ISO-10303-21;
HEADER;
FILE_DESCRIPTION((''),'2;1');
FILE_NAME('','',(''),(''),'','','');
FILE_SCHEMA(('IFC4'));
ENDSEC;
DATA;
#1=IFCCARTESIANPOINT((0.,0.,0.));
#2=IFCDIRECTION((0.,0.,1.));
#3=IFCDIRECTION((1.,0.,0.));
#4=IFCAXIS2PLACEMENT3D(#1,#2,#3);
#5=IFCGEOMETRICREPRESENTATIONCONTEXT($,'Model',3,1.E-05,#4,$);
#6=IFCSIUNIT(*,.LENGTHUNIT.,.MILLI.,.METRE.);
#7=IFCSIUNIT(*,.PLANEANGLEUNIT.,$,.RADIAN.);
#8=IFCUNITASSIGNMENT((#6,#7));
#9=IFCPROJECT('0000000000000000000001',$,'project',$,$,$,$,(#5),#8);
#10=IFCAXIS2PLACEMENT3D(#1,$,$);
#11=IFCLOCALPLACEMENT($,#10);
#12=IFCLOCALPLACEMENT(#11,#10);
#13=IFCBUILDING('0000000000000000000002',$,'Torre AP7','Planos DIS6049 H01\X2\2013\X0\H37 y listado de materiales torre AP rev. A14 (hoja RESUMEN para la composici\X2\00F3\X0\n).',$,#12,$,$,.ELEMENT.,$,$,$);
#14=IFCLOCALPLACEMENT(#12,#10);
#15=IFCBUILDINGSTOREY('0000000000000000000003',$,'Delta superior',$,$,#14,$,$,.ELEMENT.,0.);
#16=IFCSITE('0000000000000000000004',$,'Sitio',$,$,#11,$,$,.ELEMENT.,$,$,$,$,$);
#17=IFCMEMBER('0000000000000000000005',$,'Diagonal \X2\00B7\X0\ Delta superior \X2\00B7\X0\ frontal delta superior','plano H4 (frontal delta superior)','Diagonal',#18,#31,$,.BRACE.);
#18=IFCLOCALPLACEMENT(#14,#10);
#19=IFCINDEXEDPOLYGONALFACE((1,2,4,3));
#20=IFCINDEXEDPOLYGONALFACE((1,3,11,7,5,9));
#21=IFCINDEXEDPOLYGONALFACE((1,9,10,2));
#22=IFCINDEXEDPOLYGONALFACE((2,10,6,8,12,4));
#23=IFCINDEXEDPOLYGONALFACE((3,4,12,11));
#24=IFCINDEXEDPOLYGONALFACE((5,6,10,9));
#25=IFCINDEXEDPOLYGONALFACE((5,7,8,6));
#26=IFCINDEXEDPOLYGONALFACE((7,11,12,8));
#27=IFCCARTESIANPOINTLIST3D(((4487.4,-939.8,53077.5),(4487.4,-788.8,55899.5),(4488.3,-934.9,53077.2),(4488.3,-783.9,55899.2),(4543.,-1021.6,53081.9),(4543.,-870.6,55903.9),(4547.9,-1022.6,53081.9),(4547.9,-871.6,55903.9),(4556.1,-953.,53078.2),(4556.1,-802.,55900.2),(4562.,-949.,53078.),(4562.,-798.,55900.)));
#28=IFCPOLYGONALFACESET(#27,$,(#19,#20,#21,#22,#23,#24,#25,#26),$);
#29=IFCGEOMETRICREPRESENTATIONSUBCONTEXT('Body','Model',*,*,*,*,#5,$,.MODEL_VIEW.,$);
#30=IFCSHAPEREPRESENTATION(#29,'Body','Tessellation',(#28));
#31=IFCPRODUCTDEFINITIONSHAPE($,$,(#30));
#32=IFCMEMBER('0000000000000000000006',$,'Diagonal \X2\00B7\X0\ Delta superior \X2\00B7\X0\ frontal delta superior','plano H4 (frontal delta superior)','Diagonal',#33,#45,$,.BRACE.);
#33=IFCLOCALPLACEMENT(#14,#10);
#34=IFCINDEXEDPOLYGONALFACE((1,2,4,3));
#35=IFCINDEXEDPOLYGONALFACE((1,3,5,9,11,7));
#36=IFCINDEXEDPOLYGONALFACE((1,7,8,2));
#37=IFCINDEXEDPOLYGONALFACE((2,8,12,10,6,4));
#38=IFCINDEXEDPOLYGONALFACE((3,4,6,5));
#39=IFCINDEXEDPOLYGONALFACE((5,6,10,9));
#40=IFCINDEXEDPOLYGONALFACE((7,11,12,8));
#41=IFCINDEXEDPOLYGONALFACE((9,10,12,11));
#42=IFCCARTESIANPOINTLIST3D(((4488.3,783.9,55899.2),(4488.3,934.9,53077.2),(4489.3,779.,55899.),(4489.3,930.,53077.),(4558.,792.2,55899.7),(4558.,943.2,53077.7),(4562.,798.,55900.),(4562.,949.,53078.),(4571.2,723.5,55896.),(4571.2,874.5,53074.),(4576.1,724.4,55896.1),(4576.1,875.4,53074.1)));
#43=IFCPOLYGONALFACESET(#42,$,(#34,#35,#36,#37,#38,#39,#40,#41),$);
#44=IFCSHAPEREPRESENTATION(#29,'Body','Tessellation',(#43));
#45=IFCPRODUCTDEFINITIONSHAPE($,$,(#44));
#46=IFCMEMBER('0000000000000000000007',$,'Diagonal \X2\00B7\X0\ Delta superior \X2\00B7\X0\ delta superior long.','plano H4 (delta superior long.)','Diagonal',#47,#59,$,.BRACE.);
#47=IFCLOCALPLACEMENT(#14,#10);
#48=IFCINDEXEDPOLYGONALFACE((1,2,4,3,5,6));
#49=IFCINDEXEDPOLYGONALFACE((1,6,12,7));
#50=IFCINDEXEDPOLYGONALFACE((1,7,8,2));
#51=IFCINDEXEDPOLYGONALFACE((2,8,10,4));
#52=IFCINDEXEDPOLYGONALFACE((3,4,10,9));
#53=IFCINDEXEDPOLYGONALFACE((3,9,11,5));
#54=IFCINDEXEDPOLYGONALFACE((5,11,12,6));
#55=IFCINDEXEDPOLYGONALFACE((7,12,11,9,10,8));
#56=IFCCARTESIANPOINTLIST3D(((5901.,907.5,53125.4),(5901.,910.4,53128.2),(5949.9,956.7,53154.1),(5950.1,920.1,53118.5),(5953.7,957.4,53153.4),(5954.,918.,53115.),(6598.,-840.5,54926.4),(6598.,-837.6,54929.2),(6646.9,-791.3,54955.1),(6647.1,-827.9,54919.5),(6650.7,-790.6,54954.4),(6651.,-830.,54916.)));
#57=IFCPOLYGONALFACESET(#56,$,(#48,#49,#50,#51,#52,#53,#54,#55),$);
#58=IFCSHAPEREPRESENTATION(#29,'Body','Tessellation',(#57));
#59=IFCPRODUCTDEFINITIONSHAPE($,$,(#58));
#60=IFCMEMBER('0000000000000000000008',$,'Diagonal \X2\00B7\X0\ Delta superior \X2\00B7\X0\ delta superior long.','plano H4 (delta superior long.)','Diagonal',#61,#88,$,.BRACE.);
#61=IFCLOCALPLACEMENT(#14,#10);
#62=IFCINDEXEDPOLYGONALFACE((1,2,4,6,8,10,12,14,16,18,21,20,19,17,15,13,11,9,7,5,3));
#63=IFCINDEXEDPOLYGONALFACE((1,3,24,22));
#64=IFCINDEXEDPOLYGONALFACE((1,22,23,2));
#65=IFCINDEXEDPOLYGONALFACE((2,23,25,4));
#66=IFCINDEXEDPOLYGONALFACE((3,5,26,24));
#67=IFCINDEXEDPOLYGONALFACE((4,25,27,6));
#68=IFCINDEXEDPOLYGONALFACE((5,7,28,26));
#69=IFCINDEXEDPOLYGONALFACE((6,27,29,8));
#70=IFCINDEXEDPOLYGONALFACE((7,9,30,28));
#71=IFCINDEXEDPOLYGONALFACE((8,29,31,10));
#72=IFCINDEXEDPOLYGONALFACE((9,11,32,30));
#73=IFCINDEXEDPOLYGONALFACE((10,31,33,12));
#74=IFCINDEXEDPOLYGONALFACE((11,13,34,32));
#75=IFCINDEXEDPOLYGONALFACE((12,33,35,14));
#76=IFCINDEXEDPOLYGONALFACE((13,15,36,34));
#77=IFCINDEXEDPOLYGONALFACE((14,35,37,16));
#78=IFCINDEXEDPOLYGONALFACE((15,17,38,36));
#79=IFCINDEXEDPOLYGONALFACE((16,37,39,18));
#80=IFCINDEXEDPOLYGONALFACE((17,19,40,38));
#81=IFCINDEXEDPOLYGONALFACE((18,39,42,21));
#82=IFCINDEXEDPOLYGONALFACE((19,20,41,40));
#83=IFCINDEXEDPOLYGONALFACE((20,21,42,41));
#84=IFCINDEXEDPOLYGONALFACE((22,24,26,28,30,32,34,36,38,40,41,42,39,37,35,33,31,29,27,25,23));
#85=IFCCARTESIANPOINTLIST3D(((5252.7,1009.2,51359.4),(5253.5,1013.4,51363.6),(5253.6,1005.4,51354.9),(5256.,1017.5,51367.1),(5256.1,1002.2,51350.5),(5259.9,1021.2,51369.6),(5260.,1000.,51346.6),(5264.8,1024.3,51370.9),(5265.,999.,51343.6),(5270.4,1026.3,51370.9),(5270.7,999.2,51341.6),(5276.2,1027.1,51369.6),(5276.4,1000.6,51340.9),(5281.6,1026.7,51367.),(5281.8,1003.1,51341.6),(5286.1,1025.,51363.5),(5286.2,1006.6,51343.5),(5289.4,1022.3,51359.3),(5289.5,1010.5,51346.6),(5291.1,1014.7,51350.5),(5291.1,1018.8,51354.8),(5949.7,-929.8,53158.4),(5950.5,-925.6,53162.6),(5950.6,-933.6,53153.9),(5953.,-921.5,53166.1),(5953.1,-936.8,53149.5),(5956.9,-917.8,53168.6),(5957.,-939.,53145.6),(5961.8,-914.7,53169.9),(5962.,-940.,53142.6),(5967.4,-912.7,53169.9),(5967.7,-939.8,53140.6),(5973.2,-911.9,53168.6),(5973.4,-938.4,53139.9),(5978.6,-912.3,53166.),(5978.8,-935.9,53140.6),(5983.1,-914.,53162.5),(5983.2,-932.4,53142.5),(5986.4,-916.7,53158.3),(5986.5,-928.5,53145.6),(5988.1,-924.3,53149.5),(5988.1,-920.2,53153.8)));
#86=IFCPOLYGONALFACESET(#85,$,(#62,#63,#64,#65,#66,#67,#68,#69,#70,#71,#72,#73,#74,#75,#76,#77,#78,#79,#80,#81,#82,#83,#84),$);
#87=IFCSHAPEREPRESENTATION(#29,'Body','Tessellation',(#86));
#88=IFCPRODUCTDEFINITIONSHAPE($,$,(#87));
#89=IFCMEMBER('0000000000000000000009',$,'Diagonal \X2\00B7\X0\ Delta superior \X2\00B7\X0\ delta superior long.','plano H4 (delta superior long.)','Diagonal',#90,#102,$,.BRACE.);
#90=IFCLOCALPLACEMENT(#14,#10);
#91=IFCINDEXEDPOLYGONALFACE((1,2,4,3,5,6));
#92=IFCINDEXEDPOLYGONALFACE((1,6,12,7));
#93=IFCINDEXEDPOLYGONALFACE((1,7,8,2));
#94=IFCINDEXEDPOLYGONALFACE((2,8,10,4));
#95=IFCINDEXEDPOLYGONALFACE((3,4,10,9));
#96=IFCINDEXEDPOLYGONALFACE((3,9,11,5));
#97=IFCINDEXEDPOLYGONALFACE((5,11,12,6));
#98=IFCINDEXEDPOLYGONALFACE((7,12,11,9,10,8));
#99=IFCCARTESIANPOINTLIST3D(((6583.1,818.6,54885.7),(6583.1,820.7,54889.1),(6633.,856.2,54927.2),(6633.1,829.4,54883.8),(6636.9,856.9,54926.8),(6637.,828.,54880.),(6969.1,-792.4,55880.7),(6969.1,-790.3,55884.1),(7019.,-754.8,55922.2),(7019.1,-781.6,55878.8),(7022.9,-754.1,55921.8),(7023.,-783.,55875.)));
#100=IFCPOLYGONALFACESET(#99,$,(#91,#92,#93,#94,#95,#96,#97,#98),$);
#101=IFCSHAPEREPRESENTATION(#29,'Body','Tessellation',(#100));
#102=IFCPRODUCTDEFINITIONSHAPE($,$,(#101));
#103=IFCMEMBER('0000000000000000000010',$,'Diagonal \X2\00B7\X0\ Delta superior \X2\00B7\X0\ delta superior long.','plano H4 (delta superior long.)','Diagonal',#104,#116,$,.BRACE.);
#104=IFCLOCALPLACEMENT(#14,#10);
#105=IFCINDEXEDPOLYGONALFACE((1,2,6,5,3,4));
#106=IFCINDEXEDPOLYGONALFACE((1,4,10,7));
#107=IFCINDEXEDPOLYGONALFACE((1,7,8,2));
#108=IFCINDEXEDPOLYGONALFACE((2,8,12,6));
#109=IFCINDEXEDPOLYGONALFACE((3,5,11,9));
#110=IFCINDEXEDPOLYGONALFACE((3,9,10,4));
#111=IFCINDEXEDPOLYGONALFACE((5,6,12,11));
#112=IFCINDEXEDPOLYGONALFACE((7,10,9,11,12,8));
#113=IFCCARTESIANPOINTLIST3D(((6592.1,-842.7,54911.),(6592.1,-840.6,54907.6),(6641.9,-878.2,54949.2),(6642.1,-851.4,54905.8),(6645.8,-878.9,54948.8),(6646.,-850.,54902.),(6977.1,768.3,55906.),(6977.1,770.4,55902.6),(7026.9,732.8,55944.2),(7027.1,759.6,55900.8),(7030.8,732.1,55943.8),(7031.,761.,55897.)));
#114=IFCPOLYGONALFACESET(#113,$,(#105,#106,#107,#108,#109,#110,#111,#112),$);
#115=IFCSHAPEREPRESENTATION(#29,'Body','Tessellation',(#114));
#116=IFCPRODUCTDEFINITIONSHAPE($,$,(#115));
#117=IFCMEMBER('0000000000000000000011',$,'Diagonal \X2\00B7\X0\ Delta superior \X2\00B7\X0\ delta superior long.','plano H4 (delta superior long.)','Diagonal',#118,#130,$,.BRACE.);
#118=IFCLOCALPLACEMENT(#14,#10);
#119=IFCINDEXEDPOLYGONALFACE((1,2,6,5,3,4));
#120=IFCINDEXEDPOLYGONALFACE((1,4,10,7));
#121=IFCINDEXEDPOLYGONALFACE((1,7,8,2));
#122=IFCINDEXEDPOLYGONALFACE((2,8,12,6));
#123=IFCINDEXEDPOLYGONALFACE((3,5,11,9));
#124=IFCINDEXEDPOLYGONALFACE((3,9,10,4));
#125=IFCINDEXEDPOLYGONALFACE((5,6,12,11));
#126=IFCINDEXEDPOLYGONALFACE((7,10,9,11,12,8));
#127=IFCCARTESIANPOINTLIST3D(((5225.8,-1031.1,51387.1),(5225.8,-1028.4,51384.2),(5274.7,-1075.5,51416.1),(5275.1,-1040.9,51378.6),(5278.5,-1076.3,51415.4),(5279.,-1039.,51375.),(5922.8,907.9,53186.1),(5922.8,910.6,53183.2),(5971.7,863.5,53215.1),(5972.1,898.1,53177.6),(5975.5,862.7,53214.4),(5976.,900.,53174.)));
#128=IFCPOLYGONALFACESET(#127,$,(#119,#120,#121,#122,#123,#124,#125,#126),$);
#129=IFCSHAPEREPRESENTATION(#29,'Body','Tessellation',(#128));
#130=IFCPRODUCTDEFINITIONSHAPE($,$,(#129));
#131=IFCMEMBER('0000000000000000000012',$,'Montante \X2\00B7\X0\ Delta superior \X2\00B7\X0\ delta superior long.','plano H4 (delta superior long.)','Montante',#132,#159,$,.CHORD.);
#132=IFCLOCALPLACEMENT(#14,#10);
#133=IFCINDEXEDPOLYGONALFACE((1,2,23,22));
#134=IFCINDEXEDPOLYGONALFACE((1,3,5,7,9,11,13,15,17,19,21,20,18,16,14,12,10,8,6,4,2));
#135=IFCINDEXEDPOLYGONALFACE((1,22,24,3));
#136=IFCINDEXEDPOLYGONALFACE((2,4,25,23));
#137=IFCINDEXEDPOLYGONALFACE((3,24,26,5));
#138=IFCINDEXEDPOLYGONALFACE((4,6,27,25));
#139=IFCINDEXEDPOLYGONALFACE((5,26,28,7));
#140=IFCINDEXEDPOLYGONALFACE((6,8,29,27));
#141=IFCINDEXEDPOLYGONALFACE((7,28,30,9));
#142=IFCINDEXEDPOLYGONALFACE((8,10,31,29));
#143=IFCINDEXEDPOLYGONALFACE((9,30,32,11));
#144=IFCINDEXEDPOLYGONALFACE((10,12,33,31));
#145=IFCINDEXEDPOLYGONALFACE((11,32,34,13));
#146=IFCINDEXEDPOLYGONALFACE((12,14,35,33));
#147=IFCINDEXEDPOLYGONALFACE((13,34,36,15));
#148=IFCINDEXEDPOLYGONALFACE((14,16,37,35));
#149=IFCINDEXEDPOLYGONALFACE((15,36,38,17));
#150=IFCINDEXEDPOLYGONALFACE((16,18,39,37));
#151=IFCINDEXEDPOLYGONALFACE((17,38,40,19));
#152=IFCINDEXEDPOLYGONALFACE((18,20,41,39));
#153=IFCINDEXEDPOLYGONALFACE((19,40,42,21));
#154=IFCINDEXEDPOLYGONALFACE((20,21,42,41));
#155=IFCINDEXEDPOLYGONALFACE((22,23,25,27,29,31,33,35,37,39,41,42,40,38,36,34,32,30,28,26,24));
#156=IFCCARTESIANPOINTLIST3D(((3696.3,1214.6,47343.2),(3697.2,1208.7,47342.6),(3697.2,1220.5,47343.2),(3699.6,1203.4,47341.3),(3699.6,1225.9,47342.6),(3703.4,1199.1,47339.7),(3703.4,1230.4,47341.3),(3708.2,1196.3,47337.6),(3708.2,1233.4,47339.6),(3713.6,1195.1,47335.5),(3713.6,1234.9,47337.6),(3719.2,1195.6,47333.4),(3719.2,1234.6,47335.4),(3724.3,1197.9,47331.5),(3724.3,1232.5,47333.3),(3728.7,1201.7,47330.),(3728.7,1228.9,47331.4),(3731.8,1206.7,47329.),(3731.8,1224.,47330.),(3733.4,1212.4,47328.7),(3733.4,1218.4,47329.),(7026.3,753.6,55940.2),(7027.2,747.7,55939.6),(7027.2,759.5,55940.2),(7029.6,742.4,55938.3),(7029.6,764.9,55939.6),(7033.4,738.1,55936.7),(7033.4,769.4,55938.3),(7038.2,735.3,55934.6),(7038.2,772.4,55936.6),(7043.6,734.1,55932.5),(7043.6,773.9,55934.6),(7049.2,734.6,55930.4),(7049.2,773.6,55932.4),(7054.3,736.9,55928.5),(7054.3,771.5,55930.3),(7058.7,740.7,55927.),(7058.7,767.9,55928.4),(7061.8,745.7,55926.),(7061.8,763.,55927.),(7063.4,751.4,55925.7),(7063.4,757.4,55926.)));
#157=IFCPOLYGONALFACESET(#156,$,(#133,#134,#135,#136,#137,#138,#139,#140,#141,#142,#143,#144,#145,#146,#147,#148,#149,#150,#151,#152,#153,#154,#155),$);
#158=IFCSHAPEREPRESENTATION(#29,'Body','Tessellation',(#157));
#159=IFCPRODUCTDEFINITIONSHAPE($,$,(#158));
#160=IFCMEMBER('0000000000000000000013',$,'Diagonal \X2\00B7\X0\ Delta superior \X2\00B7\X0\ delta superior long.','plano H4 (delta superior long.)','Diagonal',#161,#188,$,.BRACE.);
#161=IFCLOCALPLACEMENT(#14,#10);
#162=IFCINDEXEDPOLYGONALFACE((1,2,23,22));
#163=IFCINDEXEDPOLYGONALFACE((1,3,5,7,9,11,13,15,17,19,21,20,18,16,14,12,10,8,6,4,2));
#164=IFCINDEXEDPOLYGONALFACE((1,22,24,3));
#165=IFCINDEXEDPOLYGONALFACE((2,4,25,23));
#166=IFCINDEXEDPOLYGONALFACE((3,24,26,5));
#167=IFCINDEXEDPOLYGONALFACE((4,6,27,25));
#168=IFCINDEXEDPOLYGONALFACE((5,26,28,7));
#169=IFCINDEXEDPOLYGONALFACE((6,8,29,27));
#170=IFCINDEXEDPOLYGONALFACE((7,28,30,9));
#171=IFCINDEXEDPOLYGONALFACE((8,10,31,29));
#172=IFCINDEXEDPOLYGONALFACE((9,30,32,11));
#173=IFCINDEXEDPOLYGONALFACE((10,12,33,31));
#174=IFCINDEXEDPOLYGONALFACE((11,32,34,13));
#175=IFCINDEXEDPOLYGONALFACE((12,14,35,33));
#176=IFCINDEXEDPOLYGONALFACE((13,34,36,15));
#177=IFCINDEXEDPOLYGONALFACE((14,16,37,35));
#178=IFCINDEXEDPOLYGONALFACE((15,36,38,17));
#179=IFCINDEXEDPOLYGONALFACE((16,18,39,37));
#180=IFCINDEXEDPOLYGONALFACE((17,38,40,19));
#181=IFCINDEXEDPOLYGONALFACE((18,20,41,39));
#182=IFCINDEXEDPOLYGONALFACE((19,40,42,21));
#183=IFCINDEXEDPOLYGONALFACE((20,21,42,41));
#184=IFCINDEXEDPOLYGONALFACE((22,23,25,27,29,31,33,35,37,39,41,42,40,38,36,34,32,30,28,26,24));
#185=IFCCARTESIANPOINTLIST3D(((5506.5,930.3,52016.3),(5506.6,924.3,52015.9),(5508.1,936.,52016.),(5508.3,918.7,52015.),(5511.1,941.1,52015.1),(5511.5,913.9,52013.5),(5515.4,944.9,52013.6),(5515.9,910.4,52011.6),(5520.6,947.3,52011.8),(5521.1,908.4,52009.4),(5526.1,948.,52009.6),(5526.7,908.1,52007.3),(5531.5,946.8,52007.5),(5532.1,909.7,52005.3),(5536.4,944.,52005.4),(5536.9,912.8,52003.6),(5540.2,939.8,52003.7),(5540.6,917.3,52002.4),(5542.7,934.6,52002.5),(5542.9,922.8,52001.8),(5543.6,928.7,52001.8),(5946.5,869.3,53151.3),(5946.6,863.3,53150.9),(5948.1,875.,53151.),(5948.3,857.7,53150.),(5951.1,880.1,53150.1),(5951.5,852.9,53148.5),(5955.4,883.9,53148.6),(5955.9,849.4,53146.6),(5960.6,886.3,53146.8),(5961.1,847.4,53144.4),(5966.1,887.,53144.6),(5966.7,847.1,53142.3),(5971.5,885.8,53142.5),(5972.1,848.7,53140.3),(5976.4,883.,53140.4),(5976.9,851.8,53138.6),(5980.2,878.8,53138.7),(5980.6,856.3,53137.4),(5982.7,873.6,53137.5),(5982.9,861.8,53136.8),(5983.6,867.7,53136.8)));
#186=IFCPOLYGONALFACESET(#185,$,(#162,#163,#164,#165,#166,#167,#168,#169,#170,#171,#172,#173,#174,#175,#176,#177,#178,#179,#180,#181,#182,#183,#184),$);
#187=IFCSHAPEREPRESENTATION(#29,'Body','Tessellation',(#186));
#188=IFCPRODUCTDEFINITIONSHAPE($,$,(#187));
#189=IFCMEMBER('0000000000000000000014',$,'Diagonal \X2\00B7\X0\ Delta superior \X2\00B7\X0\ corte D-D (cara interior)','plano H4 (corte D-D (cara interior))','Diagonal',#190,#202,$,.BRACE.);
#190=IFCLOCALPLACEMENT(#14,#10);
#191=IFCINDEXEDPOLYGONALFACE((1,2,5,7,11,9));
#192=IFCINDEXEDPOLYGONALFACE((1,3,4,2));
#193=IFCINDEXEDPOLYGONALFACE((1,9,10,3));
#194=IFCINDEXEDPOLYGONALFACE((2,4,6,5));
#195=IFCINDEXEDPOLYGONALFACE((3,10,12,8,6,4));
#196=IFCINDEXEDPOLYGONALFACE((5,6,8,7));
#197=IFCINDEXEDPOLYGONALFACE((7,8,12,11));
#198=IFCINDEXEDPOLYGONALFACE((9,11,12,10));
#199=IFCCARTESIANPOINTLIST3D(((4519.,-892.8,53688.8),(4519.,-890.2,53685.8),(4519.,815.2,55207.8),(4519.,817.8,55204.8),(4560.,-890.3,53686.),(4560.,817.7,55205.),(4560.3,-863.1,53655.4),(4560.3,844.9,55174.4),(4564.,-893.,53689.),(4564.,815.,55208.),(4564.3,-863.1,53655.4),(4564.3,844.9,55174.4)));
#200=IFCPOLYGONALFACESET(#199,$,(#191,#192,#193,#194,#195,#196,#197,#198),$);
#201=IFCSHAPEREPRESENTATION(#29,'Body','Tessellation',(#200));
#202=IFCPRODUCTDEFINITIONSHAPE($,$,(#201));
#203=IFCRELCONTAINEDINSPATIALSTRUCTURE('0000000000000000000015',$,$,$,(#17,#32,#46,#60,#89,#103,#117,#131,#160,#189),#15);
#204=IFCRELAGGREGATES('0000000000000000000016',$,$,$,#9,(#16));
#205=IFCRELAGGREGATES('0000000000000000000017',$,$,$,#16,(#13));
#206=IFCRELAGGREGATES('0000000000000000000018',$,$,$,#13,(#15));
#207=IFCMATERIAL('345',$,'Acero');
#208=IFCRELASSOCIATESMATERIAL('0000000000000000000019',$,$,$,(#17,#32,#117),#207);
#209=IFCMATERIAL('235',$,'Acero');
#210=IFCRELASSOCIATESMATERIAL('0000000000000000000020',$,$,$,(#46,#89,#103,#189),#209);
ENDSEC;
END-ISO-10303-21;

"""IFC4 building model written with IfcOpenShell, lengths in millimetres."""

from ifc_helpers import new_model, si_unit, frame, frame_2d, origin, origin_with_axes, place, context, subcontext, project, spatial, circle, l_section, extrude, material, element, save


model = new_model("IFC4")

# Units and contexts
model_context = context("Model", 3, precision=1e-05, world=origin_with_axes())
body_context = subcontext(model_context, "Body", "Model", "MODEL_VIEW")
ifc_project = project(units=[si_unit("LENGTHUNIT", "METRE", prefix="MILLI"), si_unit("PLANEANGLEUNIT", "RADIAN")], contexts=[model_context])

# Site, building, storey
site_placement = place(None, origin())
site = spatial("IfcSite", under=ifc_project, at=site_placement, Name="Sitio", CompositionType="ELEMENT")
building_placement = place(site_placement, origin())
building = spatial("IfcBuilding", under=site, at=building_placement, Name="Torre AP7", Description="Planos DIS6049 H01–H37 y listado de materiales torre AP rev. A14 (hoja RESUMEN para la composición).", CompositionType="ELEMENT")
storey_placement = place(building_placement, origin())
storey = spatial("IfcBuildingStorey", under=building, at=storey_placement, Name="Delta superior", CompositionType="ELEMENT", Elevation=0.0)

# Members
ifc_material_1 = material(Name="235", Category="Acero")
ifc_material_2 = material(Name="345", Category="Acero")
for number, where, z_axis, x_axis, name in (
    (1, (4562.0, -949.0, 53078.0), (0.0, 0.053432, 0.998572), (-0.982208, 0.187529, -0.010034), "Diagonal · Delta superior · frontal delta superior"),
    (2, (4562.0, 949.0, 53078.0), (0.0, -0.053432, 0.998572), (-0.982208, -0.187529, -0.010034), "Diagonal · Delta superior · frontal delta superior"),
):
    element("IfcMember", number, at=place(storey_placement, frame(where, z_axis=z_axis, x_axis=x_axis)), inside=storey, material=ifc_material_2, Name=name, Description="plano H4 (frontal delta superior)", ObjectType="Diagonal", PredefinedType="BRACE", context=body_context, shape_type="SweptSolid", body=[
        extrude(l_section(Depth=75.0, Width=75.0, Thickness=5.0, at=frame_2d((37.5, 37.5))), None, (0.0, 0.0, 1.0), 2826.0),
    ])
member_1_placement = place(storey_placement, frame((6651.0, -830.0, 54916.0), z_axis=(-0.267584, 0.671072, -0.691419), x_axis=(-0.963521, -0.190088, 0.188396)))
element("IfcMember", 3, at=member_1_placement, inside=storey, material=ifc_material_1, Name="Diagonal · Delta superior · delta superior long.", Description="plano H4 (delta superior long.)", ObjectType="Diagonal", PredefinedType="BRACE", context=body_context, shape_type="SweptSolid", body=[
    extrude(l_section(Depth=55.0, Width=55.0, Thickness=4.0, at=frame_2d((27.5, 27.5))), None, (0.0, 0.0, 1.0), 2604.8),
])
member_2_placement = place(storey_placement, frame((5969.0, -926.0, 53155.0), z_axis=(-0.254816, 0.708877, -0.657695), x_axis=(-0.966975, -0.190493, 0.169325)))
element("IfcMember", 4, at=member_2_placement, inside=storey, Name="Diagonal · Delta superior · delta superior long.", Description="plano H4 (delta superior long.)", ObjectType="Diagonal", PredefinedType="BRACE", context=body_context, shape_type="SweptSolid", body=[
    extrude(circle(Radius=20.0), None, (0.0, 0.0, 1.0), 2735.3),
])
member_3_placement = place(storey_placement, frame((7023.0, -783.0, 55875.0), z_axis=(-0.199747, 0.833659, -0.514892), x_axis=(-0.979846, -0.170873, 0.103461)))
element("IfcMember", 5, at=member_3_placement, inside=storey, material=ifc_material_1, Name="Diagonal · Delta superior · delta superior long.", Description="plano H4 (delta superior long.)", ObjectType="Diagonal", PredefinedType="BRACE", context=body_context, shape_type="SweptSolid", body=[
    extrude(l_section(Depth=55.0, Width=55.0, Thickness=4.0, at=frame_2d((27.5, 27.5))), None, (0.0, 0.0, 1.0), 1932.4),
])
member_4_placement = place(storey_placement, frame((6646.0, -850.0, 54902.0), z_axis=(0.19925, 0.833745, 0.514945), x_axis=(-0.979943, 0.171353, 0.101736)))
element("IfcMember", 6, at=member_4_placement, inside=storey, material=ifc_material_1, Name="Diagonal · Delta superior · delta superior long.", Description="plano H4 (delta superior long.)", ObjectType="Diagonal", PredefinedType="BRACE", context=body_context, shape_type="SweptSolid", body=[
    extrude(l_section(Depth=55.0, Width=55.0, Thickness=4.0, at=frame_2d((27.5, 27.5))), None, (0.0, 0.0, 1.0), 1932.2),
])
member_5_placement = place(storey_placement, frame((5279.0, -1039.0, 51375.0), z_axis=(0.254816, 0.708877, 0.657695), x_axis=(-0.966953, 0.192686, 0.166953)))
element("IfcMember", 7, at=member_5_placement, inside=storey, material=ifc_material_2, Name="Diagonal · Delta superior · delta superior long.", Description="plano H4 (delta superior long.)", ObjectType="Diagonal", PredefinedType="BRACE", context=body_context, shape_type="SweptSolid", body=[
    extrude(l_section(Depth=55.0, Width=55.0, Thickness=4.0, at=frame_2d((27.5, 27.5))), None, (0.0, 0.0, 1.0), 2735.3),
])
for number, where, z_axis, x_axis, name in (
    (8, (3715.0, 1215.0, 47336.0), (0.360744, -0.049941, 0.931327), (-0.932665, -0.019317, 0.360227), "Montante · Delta superior · delta superior long."),
):
    element("IfcMember", number, at=place(storey_placement, frame(where, z_axis=z_axis, x_axis=x_axis)), inside=storey, Name=name, Description="plano H4 (delta superior long.)", ObjectType="Montante", PredefinedType="CHORD", context=body_context, shape_type="SweptSolid", body=[
        extrude(circle(Radius=20.0), None, (0.0, 0.0, 1.0), 9230.9),
    ])
member_6_placement = place(storey_placement, frame((5525.0, 928.0, 52009.0), z_axis=(0.361002, -0.050048, 0.931221), x_axis=(-0.919866, -0.183339, 0.346747)))
element("IfcMember", 9, at=member_6_placement, inside=storey, Name="Diagonal · Delta superior · delta superior long.", Description="plano H4 (delta superior long.)", ObjectType="Diagonal", PredefinedType="BRACE", context=body_context, shape_type="SweptSolid", body=[
    extrude(circle(Radius=20.0), None, (0.0, 0.0, 1.0), 1218.8),
])
member_7_placement = place(storey_placement, frame((4564.0, 815.0, 55208.0), z_axis=(0.0, -0.74724, -0.664554), x_axis=(-0.999984, 0.003774, -0.004243)))
element("IfcMember", 10, at=member_7_placement, inside=storey, material=ifc_material_1, Name="Diagonal · Delta superior · corte D-D (cara interior)", Description="plano H4 (corte D-D (cara interior))", ObjectType="Diagonal", PredefinedType="BRACE", context=body_context, shape_type="SweptSolid", body=[
    extrude(l_section(Depth=45.0, Width=45.0, Thickness=4.0, at=frame_2d((22.5, 22.5))), None, (0.0, 0.0, 1.0), 2285.7),
])

save(model, "model.ifc")
